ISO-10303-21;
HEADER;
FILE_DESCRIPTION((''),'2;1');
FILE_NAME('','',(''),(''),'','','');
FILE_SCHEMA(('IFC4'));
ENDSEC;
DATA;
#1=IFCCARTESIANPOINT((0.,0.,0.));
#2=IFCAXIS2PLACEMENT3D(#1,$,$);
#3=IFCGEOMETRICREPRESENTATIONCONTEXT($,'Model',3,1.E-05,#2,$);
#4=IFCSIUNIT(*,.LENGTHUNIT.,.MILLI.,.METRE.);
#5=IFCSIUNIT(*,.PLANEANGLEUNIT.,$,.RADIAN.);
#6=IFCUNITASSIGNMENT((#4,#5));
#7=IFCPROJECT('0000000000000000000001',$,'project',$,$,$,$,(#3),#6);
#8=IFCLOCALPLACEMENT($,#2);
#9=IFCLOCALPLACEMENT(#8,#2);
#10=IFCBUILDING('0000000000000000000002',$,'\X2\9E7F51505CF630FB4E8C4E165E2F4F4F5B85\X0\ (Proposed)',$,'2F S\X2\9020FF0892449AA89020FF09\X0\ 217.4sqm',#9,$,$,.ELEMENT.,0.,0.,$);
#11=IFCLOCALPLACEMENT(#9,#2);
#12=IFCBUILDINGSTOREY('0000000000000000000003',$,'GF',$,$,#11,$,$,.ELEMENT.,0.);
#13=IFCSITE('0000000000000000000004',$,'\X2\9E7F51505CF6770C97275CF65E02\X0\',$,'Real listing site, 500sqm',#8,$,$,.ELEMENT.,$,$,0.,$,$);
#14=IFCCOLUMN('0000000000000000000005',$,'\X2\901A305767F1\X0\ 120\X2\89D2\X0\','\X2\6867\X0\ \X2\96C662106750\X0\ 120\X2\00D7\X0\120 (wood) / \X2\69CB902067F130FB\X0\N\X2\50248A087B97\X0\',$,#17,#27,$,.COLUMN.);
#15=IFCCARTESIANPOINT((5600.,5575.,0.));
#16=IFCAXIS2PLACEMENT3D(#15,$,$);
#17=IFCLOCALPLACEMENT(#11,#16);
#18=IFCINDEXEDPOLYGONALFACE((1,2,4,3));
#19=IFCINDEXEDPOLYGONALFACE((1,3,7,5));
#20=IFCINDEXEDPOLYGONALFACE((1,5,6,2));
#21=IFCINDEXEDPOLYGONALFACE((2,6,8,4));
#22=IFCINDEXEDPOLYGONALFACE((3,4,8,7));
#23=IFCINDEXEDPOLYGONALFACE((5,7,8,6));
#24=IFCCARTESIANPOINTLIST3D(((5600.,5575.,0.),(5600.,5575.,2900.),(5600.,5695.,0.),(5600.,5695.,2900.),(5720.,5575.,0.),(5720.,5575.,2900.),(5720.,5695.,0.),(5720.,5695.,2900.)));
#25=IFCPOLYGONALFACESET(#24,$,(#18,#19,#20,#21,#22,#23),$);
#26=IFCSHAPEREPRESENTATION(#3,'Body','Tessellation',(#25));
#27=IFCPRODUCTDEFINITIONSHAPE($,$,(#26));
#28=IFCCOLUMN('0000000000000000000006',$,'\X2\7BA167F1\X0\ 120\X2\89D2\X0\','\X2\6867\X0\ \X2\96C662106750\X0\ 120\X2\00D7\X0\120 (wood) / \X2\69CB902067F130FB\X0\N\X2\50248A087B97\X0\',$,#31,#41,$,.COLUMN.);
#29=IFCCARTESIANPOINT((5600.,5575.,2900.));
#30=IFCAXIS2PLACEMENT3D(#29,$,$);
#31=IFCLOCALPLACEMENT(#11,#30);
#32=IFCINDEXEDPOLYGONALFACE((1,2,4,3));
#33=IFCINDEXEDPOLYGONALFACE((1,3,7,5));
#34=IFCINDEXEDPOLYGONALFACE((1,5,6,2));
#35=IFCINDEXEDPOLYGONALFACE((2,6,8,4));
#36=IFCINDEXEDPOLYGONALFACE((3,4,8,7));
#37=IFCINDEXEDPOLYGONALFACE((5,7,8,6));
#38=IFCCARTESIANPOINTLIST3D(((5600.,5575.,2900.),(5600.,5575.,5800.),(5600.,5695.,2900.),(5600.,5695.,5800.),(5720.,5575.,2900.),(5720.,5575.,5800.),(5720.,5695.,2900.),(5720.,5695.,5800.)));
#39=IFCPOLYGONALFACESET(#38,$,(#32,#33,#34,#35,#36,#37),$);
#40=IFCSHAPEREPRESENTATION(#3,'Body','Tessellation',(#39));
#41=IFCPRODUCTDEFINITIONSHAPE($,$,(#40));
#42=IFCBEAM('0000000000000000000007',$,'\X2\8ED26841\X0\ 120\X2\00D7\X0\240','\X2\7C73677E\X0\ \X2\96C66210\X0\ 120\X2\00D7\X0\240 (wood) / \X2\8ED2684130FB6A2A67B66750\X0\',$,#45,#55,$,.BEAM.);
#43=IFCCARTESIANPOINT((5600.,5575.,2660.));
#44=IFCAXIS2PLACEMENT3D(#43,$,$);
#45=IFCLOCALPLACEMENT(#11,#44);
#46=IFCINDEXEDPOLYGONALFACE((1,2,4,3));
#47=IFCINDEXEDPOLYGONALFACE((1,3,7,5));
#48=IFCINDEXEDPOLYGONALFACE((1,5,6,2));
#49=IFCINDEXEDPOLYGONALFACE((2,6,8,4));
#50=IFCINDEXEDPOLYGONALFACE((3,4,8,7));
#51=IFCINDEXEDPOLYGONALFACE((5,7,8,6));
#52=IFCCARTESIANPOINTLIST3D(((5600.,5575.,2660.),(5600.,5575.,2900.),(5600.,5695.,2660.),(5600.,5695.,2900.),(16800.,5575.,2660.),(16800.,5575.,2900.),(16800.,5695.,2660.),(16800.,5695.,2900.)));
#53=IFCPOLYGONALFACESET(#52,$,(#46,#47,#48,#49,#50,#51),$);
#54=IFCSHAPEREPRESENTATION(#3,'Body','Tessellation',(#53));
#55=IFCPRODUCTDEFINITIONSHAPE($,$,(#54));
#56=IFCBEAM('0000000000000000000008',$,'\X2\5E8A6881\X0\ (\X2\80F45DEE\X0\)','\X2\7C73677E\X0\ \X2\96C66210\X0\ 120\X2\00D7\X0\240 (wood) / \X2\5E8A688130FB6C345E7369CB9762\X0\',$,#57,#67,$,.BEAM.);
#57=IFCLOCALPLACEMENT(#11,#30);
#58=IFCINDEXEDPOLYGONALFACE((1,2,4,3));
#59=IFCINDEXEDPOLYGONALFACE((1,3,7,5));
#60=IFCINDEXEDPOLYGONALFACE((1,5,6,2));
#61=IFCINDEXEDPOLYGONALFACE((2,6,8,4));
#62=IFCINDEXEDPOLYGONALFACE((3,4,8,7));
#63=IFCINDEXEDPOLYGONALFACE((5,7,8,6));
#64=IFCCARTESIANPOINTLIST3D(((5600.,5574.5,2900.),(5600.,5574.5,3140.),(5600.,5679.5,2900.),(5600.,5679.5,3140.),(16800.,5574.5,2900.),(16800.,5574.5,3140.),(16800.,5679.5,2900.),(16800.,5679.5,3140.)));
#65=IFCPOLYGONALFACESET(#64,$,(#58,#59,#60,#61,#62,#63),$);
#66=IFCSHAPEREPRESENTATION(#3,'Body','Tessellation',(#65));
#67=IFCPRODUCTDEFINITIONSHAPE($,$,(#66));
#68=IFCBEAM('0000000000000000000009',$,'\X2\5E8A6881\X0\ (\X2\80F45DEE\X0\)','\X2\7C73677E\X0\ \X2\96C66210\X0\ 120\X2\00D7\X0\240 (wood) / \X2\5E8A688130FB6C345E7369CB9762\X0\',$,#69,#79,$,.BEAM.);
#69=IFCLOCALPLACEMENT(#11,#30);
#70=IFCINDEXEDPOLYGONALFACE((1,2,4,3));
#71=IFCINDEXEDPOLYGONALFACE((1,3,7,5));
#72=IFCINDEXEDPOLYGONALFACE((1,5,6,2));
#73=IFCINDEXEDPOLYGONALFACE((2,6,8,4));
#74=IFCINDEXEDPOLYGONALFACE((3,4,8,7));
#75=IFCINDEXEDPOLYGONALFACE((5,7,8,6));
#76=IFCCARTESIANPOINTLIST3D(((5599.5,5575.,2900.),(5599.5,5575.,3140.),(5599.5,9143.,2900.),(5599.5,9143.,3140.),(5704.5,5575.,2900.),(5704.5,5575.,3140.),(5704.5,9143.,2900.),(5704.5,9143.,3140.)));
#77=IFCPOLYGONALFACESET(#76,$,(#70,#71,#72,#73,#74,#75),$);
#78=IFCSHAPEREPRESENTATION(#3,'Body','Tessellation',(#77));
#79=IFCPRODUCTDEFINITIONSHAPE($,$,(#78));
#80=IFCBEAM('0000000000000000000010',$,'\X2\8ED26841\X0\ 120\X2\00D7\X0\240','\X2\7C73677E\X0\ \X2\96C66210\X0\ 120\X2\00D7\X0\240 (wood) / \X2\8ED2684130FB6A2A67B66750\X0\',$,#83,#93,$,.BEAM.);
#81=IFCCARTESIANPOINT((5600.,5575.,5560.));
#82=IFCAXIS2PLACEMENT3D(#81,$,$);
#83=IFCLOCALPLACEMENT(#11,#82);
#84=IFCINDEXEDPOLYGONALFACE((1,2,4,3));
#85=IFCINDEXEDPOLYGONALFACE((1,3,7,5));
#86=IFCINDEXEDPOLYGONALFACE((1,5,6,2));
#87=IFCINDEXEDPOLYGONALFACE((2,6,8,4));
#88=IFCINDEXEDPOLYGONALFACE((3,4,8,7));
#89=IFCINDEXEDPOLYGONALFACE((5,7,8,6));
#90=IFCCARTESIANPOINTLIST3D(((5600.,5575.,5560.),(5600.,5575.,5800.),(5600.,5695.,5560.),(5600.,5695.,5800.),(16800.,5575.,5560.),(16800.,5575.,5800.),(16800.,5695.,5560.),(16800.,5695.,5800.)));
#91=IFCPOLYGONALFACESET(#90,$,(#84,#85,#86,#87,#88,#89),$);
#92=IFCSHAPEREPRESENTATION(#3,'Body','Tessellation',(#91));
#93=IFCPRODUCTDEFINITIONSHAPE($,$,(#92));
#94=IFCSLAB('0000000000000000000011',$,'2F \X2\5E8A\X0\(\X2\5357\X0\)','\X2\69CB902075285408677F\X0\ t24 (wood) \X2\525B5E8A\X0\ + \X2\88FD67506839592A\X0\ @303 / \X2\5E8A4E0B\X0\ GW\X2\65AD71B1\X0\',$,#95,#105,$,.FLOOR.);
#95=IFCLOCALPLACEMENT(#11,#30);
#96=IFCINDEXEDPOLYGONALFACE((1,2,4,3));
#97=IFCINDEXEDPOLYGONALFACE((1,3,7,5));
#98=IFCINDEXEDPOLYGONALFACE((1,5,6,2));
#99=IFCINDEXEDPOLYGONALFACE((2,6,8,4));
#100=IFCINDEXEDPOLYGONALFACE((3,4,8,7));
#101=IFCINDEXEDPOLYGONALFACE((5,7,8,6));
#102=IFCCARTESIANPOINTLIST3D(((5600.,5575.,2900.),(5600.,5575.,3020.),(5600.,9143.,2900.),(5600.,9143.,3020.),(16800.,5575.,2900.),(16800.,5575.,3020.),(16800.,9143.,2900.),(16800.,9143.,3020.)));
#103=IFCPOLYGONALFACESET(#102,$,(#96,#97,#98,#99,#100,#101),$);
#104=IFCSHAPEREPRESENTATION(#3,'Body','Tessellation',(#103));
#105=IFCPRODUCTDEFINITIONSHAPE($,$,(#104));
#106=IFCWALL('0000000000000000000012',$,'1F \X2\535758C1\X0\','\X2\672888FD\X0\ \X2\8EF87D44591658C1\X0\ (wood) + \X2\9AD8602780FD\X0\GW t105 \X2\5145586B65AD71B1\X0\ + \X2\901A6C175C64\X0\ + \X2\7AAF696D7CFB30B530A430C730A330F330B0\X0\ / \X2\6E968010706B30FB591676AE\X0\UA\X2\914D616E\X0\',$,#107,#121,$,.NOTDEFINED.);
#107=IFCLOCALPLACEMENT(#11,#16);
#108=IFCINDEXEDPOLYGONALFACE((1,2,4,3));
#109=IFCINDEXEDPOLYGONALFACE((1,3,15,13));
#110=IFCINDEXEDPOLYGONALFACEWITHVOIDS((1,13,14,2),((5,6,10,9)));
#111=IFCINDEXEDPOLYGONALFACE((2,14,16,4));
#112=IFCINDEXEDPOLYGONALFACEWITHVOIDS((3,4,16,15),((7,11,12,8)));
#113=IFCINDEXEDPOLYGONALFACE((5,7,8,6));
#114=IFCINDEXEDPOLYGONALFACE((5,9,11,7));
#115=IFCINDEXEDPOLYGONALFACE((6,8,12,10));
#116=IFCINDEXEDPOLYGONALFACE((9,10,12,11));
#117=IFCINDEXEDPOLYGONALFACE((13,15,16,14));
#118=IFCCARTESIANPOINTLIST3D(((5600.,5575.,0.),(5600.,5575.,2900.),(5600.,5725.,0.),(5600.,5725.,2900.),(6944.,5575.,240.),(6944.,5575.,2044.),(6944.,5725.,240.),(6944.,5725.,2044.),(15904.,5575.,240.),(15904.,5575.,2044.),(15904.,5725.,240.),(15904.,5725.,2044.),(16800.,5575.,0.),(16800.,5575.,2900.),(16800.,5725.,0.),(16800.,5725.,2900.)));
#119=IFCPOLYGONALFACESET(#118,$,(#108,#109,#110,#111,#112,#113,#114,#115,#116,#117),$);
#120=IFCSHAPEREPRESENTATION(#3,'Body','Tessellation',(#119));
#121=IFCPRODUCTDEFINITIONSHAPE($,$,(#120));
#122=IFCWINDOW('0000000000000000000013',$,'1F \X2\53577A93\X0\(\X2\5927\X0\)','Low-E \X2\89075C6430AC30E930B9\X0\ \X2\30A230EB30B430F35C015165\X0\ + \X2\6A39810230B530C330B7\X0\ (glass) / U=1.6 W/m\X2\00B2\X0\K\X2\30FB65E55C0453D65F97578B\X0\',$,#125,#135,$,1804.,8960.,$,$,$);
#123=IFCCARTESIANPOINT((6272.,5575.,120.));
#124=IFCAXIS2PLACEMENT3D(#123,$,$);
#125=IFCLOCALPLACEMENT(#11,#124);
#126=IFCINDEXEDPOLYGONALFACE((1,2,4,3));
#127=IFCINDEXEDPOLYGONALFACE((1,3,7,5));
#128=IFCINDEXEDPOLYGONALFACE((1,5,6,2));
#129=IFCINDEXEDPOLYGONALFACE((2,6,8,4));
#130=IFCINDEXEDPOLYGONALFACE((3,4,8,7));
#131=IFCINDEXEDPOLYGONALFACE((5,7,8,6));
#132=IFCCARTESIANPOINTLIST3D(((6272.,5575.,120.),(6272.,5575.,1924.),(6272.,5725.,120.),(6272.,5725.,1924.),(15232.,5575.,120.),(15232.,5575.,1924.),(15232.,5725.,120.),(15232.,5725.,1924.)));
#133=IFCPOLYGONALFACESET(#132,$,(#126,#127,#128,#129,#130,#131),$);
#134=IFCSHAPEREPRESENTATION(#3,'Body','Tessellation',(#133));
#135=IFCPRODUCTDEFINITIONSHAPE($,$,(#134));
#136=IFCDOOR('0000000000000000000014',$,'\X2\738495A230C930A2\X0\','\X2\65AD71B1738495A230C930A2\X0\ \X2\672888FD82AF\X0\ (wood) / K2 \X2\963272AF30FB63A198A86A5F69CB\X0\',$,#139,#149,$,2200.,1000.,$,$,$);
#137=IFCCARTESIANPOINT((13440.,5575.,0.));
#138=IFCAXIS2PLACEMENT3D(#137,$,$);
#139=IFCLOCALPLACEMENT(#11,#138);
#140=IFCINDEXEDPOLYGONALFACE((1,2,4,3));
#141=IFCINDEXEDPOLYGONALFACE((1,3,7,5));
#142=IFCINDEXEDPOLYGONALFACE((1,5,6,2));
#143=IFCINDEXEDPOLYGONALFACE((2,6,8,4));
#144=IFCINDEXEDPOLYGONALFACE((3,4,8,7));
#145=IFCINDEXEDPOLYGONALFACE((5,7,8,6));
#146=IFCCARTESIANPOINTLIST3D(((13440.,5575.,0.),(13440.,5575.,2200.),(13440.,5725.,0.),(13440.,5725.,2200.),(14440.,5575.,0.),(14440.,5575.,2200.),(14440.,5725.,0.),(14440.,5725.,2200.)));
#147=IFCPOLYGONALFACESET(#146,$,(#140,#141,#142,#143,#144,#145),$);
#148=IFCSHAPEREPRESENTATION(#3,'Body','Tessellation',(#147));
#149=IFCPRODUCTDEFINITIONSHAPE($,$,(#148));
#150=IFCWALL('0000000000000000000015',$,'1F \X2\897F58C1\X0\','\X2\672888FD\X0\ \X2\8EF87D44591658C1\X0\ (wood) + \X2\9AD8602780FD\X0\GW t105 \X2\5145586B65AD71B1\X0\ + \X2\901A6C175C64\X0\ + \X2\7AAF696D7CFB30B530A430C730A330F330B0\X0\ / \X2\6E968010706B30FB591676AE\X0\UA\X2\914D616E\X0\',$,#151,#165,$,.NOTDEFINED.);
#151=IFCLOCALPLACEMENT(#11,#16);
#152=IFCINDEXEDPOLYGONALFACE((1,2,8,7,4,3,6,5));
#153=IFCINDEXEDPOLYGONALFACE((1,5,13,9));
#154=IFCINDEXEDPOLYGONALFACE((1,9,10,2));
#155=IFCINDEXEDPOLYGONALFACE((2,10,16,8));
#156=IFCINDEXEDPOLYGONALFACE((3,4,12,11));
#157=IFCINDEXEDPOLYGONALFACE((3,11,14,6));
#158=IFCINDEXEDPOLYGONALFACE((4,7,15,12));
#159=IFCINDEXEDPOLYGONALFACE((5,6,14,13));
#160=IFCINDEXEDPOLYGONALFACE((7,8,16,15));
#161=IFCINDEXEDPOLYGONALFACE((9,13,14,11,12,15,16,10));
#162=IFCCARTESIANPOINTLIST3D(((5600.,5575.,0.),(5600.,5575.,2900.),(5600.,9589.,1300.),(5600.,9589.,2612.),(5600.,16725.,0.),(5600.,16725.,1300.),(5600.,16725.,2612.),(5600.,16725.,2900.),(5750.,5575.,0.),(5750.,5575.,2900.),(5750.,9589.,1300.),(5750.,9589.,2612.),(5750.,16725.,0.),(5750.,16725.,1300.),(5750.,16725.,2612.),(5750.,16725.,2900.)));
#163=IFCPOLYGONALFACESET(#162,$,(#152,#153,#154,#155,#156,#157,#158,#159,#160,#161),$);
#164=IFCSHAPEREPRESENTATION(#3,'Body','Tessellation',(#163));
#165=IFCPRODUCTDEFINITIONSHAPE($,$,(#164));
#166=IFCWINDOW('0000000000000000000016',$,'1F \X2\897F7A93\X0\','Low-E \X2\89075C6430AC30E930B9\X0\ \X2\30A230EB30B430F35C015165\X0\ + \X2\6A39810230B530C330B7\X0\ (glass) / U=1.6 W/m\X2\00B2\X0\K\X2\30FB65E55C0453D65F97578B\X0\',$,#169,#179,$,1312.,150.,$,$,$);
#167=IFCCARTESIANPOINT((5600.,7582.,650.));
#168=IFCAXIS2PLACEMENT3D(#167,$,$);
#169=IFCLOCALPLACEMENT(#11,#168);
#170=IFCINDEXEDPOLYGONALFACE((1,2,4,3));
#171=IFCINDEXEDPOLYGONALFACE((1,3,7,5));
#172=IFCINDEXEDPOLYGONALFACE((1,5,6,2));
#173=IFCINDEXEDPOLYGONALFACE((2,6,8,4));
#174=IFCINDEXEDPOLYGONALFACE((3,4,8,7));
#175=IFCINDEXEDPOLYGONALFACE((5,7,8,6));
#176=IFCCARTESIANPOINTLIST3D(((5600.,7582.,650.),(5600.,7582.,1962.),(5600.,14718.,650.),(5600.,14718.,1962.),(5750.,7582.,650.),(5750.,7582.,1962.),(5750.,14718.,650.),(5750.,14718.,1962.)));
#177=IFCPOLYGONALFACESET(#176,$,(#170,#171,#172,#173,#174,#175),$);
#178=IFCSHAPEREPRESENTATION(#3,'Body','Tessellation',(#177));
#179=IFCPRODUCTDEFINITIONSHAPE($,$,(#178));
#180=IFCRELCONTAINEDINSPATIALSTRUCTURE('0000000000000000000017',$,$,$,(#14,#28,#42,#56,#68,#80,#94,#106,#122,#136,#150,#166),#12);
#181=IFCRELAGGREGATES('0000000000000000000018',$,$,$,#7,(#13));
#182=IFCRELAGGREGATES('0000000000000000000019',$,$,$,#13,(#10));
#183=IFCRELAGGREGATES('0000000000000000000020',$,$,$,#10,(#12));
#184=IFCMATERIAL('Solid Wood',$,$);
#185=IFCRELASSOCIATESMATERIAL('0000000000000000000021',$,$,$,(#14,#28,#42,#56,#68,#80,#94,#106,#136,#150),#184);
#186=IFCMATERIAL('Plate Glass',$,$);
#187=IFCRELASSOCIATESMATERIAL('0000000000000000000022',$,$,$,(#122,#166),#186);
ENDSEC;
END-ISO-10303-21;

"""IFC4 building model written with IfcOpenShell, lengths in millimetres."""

from ifc_helpers import new_model, si_unit, frame, frame_2d, origin, place, context, project, spatial, rectangle, extrude, material, element, fill, save


model = new_model("IFC4")

# Units and contexts
model_context = context("Model", 3, precision=1e-05, world=origin())
ifc_project = project(units=[si_unit("LENGTHUNIT", "METRE", prefix="MILLI"), si_unit("PLANEANGLEUNIT", "RADIAN")], contexts=[model_context])

# Site, building, storey
site_placement = place(None, origin())
site = spatial("IfcSite", under=ifc_project, at=site_placement, Name="鹿児島県霧島市", ObjectType="Real listing site, 500sqm", CompositionType="ELEMENT", RefElevation=0.0)
building_placement = place(site_placement, origin())
building = spatial("IfcBuilding", under=site, at=building_placement, Name="鹿児島・二世帯住宅 (Proposed)", ObjectType="2F S造（鉄骨造） 217.4sqm", CompositionType="ELEMENT", ElevationOfRefHeight=0.0, ElevationOfTerrain=0.0)
storey_placement = place(building_placement, origin())
storey = spatial("IfcBuildingStorey", under=building, at=storey_placement, Name="GF", CompositionType="ELEMENT", Elevation=0.0)

# Columns
ifc_material_1 = material(Name="Solid Wood")
column_1_placement = place(storey_placement, frame((5600.0, 5575.0, 0.0)))
element("IfcColumn", 1, at=column_1_placement, inside=storey, material=ifc_material_1, Name="通し柱 120角", Description="桧 集成材 120×120 (wood) / 構造柱・N値計算", PredefinedType="COLUMN", context=model_context, shape_type="SweptSolid", body=[
    extrude(rectangle(XDim=120.0, YDim=120.0, at=frame_2d((60.0, 60.0))), frame((5600.0, 5575.0, 0.0)), (0.0, 0.0, 1.0), 2900.0),
])
column_2_placement = place(storey_placement, frame((5600.0, 5575.0, 2900.0)))
element("IfcColumn", 2, at=column_2_placement, inside=storey, material=ifc_material_1, Name="管柱 120角", Description="桧 集成材 120×120 (wood) / 構造柱・N値計算", PredefinedType="COLUMN", context=model_context, shape_type="SweptSolid", body=[
    extrude(rectangle(XDim=120.0, YDim=120.0, at=frame_2d((60.0, 60.0))), frame((5600.0, 5575.0, 2900.0)), (0.0, 0.0, 1.0), 2900.0),
])

# Beams
beam_1_placement = place(storey_placement, frame((5600.0, 5575.0, 2660.0)))
element("IfcBeam", 3, at=beam_1_placement, inside=storey, material=ifc_material_1, Name="軒桁 120×240", Description="米松 集成 120×240 (wood) / 軒桁・横架材", PredefinedType="BEAM", context=model_context, shape_type="SweptSolid", body=[
    extrude(rectangle(XDim=11200.0, YDim=120.0, at=frame_2d((5600.0, 60.0))), frame((5600.0, 5575.0, 2660.0)), (0.0, 0.0, 1.0), 240.0),
])
beam_2_placement = place(storey_placement, frame((5600.0, 5575.0, 2900.0)))
element("IfcBeam", 4, at=beam_2_placement, inside=storey, material=ifc_material_1, Name="床梁 (胴差)", Description="米松 集成 120×240 (wood) / 床梁・水平構面", PredefinedType="BEAM", context=model_context, shape_type="SweptSolid", body=[
    extrude(rectangle(XDim=11200.0, YDim=105.0, at=frame_2d((5600.0, 52.0))), frame((5600.0, 5575.0, 2900.0)), (0.0, 0.0, 1.0), 240.0),
])
beam_3_placement = place(storey_placement, frame((5600.0, 5575.0, 2900.0)))
element("IfcBeam", 5, at=beam_3_placement, inside=storey, material=ifc_material_1, Name="床梁 (胴差)", Description="米松 集成 120×240 (wood) / 床梁・水平構面", PredefinedType="BEAM", context=model_context, shape_type="SweptSolid", body=[
    extrude(rectangle(XDim=105.0, YDim=3568.0, at=frame_2d((52.0, 1784.0))), frame((5600.0, 5575.0, 2900.0)), (0.0, 0.0, 1.0), 240.0),
])
beam_4_placement = place(storey_placement, frame((5600.0, 5575.0, 5560.0)))
element("IfcBeam", 6, at=beam_4_placement, inside=storey, material=ifc_material_1, Name="軒桁 120×240", Description="米松 集成 120×240 (wood) / 軒桁・横架材", PredefinedType="BEAM", context=model_context, shape_type="SweptSolid", body=[
    extrude(rectangle(XDim=11200.0, YDim=120.0, at=frame_2d((5600.0, 60.0))), frame((5600.0, 5575.0, 5560.0)), (0.0, 0.0, 1.0), 240.0),
])

# Slab
slab_1_placement = place(storey_placement, frame((5600.0, 5575.0, 2900.0)))
element("IfcSlab", 7, at=slab_1_placement, inside=storey, material=ifc_material_1, Name="2F 床(南)", Description="構造用合板 t24 (wood) 剛床 + 製材根太 @303 / 床下 GW断熱", PredefinedType="FLOOR", context=model_context, shape_type="SweptSolid", body=[
    extrude(rectangle(XDim=11200.0, YDim=3568.0, at=frame_2d((5600.0, 1784.0))), frame((5600.0, 5575.0, 2900.0)), (0.0, 0.0, 1.0), 120.0),
])

# Wall, openings, window, door
wall_1_placement = place(storey_placement, frame((5600.0, 5575.0, 0.0)))
wall_1 = element("IfcWall", 8, at=wall_1_placement, inside=storey, material=ifc_material_1, Name="1F 南壁", Description="木製 軸組外壁 (wood) + 高性能GW t105 充填断熱 + 通気層 + 窯業系サイディング / 準耐火・外皮UA配慮", PredefinedType="NOTDEFINED", context=model_context, shape_type="SweptSolid", body=[
    extrude(rectangle(XDim=11200.0, YDim=150.0, at=frame_2d((5600.0, 75.0))), frame((5600.0, 5575.0, 0.0)), (0.0, 0.0, 1.0), 2900.0),
])
opening_1_placement = place(storey_placement, frame((6272.0, 5575.0, 120.0)))
opening_1 = element("IfcOpeningElement", 9, at=opening_1_placement, cuts=wall_1, PredefinedType="NOTDEFINED", context=model_context, shape_type="SweptSolid", body=[
    extrude(rectangle(XDim=8960.0, YDim=150.0, at=frame_2d((4480.0, 75.0))), frame((6272.0, 5575.0, 120.0)), (0.0, 0.0, 1.0), 1804.0),
])
opening_2_placement = place(storey_placement, frame((13440.0, 5575.0, 0.0)))
opening_2 = element("IfcOpeningElement", 10, at=opening_2_placement, cuts=wall_1, PredefinedType="NOTDEFINED", context=model_context, shape_type="SweptSolid", body=[
    extrude(rectangle(XDim=1000.0, YDim=150.0, at=frame_2d((500.0, 75.0))), frame((13440.0, 5575.0, 0.0)), (0.0, 0.0, 1.0), 2200.0),
])
ifc_material_2 = material(Name="Plate Glass")
window_1_placement = place(storey_placement, frame((6272.0, 5575.0, 120.0)))
window_1 = element("IfcWindow", 11, at=window_1_placement, inside=storey, material=ifc_material_2, Name="1F 南窓(大)", Description="Low-E 複層ガラス アルゴン封入 + 樹脂サッシ (glass) / U=1.6 W/m²K・日射取得型", OverallHeight=1804.0, OverallWidth=8960.0, context=model_context, shape_type="SweptSolid", body=[
    extrude(rectangle(XDim=8960.0, YDim=150.0, at=frame_2d((4480.0, 75.0))), frame((6272.0, 5575.0, 120.0)), (0.0, 0.0, 1.0), 1804.0),
])
fill(opening_1, window_1)
door_placement = place(storey_placement, frame((13440.0, 5575.0, 0.0)))
door = element("IfcDoor", 12, at=door_placement, inside=storey, material=ifc_material_1, Name="玄関ドア", Description="断熱玄関ドア 木製芯 (wood) / K2 防犯・採風機構", OverallHeight=2200.0, OverallWidth=1000.0, context=model_context, shape_type="SweptSolid", body=[
    extrude(rectangle(XDim=1000.0, YDim=150.0, at=frame_2d((500.0, 75.0))), frame((13440.0, 5575.0, 0.0)), (0.0, 0.0, 1.0), 2200.0),
])
fill(opening_2, door)

# Wall, opening, window
wall_2_placement = place(storey_placement, frame((5600.0, 5575.0, 0.0)))
wall_2 = element("IfcWall", 13, at=wall_2_placement, inside=storey, material=ifc_material_1, Name="1F 西壁", Description="木製 軸組外壁 (wood) + 高性能GW t105 充填断熱 + 通気層 + 窯業系サイディング / 準耐火・外皮UA配慮", PredefinedType="NOTDEFINED", context=model_context, shape_type="SweptSolid", body=[
    extrude(rectangle(XDim=150.0, YDim=11150.0, at=frame_2d((75.0, 5575.0))), frame((5600.0, 5575.0, 0.0)), (0.0, 0.0, 1.0), 2900.0),
])
opening_3_placement = place(storey_placement, frame((5600.0, 7582.0, 650.0)))
opening_3 = element("IfcOpeningElement", 14, at=opening_3_placement, cuts=wall_2, PredefinedType="NOTDEFINED", context=model_context, shape_type="SweptSolid", body=[
    extrude(rectangle(XDim=150.0, YDim=7136.0, at=frame_2d((75.0, 3568.0))), frame((5600.0, 7582.0, 650.0)), (0.0, 0.0, 1.0), 1312.0),
])
window_2_placement = place(storey_placement, frame((5600.0, 7582.0, 650.0)))
window_2 = element("IfcWindow", 15, at=window_2_placement, inside=storey, material=ifc_material_2, Name="1F 西窓", Description="Low-E 複層ガラス アルゴン封入 + 樹脂サッシ (glass) / U=1.6 W/m²K・日射取得型", OverallHeight=1312.0, OverallWidth=150.0, context=model_context, shape_type="SweptSolid", body=[
    extrude(rectangle(XDim=150.0, YDim=7136.0, at=frame_2d((75.0, 3568.0))), frame((5600.0, 7582.0, 650.0)), (0.0, 0.0, 1.0), 1312.0),
])
fill(opening_3, window_2)

save(model, "model.ifc")
